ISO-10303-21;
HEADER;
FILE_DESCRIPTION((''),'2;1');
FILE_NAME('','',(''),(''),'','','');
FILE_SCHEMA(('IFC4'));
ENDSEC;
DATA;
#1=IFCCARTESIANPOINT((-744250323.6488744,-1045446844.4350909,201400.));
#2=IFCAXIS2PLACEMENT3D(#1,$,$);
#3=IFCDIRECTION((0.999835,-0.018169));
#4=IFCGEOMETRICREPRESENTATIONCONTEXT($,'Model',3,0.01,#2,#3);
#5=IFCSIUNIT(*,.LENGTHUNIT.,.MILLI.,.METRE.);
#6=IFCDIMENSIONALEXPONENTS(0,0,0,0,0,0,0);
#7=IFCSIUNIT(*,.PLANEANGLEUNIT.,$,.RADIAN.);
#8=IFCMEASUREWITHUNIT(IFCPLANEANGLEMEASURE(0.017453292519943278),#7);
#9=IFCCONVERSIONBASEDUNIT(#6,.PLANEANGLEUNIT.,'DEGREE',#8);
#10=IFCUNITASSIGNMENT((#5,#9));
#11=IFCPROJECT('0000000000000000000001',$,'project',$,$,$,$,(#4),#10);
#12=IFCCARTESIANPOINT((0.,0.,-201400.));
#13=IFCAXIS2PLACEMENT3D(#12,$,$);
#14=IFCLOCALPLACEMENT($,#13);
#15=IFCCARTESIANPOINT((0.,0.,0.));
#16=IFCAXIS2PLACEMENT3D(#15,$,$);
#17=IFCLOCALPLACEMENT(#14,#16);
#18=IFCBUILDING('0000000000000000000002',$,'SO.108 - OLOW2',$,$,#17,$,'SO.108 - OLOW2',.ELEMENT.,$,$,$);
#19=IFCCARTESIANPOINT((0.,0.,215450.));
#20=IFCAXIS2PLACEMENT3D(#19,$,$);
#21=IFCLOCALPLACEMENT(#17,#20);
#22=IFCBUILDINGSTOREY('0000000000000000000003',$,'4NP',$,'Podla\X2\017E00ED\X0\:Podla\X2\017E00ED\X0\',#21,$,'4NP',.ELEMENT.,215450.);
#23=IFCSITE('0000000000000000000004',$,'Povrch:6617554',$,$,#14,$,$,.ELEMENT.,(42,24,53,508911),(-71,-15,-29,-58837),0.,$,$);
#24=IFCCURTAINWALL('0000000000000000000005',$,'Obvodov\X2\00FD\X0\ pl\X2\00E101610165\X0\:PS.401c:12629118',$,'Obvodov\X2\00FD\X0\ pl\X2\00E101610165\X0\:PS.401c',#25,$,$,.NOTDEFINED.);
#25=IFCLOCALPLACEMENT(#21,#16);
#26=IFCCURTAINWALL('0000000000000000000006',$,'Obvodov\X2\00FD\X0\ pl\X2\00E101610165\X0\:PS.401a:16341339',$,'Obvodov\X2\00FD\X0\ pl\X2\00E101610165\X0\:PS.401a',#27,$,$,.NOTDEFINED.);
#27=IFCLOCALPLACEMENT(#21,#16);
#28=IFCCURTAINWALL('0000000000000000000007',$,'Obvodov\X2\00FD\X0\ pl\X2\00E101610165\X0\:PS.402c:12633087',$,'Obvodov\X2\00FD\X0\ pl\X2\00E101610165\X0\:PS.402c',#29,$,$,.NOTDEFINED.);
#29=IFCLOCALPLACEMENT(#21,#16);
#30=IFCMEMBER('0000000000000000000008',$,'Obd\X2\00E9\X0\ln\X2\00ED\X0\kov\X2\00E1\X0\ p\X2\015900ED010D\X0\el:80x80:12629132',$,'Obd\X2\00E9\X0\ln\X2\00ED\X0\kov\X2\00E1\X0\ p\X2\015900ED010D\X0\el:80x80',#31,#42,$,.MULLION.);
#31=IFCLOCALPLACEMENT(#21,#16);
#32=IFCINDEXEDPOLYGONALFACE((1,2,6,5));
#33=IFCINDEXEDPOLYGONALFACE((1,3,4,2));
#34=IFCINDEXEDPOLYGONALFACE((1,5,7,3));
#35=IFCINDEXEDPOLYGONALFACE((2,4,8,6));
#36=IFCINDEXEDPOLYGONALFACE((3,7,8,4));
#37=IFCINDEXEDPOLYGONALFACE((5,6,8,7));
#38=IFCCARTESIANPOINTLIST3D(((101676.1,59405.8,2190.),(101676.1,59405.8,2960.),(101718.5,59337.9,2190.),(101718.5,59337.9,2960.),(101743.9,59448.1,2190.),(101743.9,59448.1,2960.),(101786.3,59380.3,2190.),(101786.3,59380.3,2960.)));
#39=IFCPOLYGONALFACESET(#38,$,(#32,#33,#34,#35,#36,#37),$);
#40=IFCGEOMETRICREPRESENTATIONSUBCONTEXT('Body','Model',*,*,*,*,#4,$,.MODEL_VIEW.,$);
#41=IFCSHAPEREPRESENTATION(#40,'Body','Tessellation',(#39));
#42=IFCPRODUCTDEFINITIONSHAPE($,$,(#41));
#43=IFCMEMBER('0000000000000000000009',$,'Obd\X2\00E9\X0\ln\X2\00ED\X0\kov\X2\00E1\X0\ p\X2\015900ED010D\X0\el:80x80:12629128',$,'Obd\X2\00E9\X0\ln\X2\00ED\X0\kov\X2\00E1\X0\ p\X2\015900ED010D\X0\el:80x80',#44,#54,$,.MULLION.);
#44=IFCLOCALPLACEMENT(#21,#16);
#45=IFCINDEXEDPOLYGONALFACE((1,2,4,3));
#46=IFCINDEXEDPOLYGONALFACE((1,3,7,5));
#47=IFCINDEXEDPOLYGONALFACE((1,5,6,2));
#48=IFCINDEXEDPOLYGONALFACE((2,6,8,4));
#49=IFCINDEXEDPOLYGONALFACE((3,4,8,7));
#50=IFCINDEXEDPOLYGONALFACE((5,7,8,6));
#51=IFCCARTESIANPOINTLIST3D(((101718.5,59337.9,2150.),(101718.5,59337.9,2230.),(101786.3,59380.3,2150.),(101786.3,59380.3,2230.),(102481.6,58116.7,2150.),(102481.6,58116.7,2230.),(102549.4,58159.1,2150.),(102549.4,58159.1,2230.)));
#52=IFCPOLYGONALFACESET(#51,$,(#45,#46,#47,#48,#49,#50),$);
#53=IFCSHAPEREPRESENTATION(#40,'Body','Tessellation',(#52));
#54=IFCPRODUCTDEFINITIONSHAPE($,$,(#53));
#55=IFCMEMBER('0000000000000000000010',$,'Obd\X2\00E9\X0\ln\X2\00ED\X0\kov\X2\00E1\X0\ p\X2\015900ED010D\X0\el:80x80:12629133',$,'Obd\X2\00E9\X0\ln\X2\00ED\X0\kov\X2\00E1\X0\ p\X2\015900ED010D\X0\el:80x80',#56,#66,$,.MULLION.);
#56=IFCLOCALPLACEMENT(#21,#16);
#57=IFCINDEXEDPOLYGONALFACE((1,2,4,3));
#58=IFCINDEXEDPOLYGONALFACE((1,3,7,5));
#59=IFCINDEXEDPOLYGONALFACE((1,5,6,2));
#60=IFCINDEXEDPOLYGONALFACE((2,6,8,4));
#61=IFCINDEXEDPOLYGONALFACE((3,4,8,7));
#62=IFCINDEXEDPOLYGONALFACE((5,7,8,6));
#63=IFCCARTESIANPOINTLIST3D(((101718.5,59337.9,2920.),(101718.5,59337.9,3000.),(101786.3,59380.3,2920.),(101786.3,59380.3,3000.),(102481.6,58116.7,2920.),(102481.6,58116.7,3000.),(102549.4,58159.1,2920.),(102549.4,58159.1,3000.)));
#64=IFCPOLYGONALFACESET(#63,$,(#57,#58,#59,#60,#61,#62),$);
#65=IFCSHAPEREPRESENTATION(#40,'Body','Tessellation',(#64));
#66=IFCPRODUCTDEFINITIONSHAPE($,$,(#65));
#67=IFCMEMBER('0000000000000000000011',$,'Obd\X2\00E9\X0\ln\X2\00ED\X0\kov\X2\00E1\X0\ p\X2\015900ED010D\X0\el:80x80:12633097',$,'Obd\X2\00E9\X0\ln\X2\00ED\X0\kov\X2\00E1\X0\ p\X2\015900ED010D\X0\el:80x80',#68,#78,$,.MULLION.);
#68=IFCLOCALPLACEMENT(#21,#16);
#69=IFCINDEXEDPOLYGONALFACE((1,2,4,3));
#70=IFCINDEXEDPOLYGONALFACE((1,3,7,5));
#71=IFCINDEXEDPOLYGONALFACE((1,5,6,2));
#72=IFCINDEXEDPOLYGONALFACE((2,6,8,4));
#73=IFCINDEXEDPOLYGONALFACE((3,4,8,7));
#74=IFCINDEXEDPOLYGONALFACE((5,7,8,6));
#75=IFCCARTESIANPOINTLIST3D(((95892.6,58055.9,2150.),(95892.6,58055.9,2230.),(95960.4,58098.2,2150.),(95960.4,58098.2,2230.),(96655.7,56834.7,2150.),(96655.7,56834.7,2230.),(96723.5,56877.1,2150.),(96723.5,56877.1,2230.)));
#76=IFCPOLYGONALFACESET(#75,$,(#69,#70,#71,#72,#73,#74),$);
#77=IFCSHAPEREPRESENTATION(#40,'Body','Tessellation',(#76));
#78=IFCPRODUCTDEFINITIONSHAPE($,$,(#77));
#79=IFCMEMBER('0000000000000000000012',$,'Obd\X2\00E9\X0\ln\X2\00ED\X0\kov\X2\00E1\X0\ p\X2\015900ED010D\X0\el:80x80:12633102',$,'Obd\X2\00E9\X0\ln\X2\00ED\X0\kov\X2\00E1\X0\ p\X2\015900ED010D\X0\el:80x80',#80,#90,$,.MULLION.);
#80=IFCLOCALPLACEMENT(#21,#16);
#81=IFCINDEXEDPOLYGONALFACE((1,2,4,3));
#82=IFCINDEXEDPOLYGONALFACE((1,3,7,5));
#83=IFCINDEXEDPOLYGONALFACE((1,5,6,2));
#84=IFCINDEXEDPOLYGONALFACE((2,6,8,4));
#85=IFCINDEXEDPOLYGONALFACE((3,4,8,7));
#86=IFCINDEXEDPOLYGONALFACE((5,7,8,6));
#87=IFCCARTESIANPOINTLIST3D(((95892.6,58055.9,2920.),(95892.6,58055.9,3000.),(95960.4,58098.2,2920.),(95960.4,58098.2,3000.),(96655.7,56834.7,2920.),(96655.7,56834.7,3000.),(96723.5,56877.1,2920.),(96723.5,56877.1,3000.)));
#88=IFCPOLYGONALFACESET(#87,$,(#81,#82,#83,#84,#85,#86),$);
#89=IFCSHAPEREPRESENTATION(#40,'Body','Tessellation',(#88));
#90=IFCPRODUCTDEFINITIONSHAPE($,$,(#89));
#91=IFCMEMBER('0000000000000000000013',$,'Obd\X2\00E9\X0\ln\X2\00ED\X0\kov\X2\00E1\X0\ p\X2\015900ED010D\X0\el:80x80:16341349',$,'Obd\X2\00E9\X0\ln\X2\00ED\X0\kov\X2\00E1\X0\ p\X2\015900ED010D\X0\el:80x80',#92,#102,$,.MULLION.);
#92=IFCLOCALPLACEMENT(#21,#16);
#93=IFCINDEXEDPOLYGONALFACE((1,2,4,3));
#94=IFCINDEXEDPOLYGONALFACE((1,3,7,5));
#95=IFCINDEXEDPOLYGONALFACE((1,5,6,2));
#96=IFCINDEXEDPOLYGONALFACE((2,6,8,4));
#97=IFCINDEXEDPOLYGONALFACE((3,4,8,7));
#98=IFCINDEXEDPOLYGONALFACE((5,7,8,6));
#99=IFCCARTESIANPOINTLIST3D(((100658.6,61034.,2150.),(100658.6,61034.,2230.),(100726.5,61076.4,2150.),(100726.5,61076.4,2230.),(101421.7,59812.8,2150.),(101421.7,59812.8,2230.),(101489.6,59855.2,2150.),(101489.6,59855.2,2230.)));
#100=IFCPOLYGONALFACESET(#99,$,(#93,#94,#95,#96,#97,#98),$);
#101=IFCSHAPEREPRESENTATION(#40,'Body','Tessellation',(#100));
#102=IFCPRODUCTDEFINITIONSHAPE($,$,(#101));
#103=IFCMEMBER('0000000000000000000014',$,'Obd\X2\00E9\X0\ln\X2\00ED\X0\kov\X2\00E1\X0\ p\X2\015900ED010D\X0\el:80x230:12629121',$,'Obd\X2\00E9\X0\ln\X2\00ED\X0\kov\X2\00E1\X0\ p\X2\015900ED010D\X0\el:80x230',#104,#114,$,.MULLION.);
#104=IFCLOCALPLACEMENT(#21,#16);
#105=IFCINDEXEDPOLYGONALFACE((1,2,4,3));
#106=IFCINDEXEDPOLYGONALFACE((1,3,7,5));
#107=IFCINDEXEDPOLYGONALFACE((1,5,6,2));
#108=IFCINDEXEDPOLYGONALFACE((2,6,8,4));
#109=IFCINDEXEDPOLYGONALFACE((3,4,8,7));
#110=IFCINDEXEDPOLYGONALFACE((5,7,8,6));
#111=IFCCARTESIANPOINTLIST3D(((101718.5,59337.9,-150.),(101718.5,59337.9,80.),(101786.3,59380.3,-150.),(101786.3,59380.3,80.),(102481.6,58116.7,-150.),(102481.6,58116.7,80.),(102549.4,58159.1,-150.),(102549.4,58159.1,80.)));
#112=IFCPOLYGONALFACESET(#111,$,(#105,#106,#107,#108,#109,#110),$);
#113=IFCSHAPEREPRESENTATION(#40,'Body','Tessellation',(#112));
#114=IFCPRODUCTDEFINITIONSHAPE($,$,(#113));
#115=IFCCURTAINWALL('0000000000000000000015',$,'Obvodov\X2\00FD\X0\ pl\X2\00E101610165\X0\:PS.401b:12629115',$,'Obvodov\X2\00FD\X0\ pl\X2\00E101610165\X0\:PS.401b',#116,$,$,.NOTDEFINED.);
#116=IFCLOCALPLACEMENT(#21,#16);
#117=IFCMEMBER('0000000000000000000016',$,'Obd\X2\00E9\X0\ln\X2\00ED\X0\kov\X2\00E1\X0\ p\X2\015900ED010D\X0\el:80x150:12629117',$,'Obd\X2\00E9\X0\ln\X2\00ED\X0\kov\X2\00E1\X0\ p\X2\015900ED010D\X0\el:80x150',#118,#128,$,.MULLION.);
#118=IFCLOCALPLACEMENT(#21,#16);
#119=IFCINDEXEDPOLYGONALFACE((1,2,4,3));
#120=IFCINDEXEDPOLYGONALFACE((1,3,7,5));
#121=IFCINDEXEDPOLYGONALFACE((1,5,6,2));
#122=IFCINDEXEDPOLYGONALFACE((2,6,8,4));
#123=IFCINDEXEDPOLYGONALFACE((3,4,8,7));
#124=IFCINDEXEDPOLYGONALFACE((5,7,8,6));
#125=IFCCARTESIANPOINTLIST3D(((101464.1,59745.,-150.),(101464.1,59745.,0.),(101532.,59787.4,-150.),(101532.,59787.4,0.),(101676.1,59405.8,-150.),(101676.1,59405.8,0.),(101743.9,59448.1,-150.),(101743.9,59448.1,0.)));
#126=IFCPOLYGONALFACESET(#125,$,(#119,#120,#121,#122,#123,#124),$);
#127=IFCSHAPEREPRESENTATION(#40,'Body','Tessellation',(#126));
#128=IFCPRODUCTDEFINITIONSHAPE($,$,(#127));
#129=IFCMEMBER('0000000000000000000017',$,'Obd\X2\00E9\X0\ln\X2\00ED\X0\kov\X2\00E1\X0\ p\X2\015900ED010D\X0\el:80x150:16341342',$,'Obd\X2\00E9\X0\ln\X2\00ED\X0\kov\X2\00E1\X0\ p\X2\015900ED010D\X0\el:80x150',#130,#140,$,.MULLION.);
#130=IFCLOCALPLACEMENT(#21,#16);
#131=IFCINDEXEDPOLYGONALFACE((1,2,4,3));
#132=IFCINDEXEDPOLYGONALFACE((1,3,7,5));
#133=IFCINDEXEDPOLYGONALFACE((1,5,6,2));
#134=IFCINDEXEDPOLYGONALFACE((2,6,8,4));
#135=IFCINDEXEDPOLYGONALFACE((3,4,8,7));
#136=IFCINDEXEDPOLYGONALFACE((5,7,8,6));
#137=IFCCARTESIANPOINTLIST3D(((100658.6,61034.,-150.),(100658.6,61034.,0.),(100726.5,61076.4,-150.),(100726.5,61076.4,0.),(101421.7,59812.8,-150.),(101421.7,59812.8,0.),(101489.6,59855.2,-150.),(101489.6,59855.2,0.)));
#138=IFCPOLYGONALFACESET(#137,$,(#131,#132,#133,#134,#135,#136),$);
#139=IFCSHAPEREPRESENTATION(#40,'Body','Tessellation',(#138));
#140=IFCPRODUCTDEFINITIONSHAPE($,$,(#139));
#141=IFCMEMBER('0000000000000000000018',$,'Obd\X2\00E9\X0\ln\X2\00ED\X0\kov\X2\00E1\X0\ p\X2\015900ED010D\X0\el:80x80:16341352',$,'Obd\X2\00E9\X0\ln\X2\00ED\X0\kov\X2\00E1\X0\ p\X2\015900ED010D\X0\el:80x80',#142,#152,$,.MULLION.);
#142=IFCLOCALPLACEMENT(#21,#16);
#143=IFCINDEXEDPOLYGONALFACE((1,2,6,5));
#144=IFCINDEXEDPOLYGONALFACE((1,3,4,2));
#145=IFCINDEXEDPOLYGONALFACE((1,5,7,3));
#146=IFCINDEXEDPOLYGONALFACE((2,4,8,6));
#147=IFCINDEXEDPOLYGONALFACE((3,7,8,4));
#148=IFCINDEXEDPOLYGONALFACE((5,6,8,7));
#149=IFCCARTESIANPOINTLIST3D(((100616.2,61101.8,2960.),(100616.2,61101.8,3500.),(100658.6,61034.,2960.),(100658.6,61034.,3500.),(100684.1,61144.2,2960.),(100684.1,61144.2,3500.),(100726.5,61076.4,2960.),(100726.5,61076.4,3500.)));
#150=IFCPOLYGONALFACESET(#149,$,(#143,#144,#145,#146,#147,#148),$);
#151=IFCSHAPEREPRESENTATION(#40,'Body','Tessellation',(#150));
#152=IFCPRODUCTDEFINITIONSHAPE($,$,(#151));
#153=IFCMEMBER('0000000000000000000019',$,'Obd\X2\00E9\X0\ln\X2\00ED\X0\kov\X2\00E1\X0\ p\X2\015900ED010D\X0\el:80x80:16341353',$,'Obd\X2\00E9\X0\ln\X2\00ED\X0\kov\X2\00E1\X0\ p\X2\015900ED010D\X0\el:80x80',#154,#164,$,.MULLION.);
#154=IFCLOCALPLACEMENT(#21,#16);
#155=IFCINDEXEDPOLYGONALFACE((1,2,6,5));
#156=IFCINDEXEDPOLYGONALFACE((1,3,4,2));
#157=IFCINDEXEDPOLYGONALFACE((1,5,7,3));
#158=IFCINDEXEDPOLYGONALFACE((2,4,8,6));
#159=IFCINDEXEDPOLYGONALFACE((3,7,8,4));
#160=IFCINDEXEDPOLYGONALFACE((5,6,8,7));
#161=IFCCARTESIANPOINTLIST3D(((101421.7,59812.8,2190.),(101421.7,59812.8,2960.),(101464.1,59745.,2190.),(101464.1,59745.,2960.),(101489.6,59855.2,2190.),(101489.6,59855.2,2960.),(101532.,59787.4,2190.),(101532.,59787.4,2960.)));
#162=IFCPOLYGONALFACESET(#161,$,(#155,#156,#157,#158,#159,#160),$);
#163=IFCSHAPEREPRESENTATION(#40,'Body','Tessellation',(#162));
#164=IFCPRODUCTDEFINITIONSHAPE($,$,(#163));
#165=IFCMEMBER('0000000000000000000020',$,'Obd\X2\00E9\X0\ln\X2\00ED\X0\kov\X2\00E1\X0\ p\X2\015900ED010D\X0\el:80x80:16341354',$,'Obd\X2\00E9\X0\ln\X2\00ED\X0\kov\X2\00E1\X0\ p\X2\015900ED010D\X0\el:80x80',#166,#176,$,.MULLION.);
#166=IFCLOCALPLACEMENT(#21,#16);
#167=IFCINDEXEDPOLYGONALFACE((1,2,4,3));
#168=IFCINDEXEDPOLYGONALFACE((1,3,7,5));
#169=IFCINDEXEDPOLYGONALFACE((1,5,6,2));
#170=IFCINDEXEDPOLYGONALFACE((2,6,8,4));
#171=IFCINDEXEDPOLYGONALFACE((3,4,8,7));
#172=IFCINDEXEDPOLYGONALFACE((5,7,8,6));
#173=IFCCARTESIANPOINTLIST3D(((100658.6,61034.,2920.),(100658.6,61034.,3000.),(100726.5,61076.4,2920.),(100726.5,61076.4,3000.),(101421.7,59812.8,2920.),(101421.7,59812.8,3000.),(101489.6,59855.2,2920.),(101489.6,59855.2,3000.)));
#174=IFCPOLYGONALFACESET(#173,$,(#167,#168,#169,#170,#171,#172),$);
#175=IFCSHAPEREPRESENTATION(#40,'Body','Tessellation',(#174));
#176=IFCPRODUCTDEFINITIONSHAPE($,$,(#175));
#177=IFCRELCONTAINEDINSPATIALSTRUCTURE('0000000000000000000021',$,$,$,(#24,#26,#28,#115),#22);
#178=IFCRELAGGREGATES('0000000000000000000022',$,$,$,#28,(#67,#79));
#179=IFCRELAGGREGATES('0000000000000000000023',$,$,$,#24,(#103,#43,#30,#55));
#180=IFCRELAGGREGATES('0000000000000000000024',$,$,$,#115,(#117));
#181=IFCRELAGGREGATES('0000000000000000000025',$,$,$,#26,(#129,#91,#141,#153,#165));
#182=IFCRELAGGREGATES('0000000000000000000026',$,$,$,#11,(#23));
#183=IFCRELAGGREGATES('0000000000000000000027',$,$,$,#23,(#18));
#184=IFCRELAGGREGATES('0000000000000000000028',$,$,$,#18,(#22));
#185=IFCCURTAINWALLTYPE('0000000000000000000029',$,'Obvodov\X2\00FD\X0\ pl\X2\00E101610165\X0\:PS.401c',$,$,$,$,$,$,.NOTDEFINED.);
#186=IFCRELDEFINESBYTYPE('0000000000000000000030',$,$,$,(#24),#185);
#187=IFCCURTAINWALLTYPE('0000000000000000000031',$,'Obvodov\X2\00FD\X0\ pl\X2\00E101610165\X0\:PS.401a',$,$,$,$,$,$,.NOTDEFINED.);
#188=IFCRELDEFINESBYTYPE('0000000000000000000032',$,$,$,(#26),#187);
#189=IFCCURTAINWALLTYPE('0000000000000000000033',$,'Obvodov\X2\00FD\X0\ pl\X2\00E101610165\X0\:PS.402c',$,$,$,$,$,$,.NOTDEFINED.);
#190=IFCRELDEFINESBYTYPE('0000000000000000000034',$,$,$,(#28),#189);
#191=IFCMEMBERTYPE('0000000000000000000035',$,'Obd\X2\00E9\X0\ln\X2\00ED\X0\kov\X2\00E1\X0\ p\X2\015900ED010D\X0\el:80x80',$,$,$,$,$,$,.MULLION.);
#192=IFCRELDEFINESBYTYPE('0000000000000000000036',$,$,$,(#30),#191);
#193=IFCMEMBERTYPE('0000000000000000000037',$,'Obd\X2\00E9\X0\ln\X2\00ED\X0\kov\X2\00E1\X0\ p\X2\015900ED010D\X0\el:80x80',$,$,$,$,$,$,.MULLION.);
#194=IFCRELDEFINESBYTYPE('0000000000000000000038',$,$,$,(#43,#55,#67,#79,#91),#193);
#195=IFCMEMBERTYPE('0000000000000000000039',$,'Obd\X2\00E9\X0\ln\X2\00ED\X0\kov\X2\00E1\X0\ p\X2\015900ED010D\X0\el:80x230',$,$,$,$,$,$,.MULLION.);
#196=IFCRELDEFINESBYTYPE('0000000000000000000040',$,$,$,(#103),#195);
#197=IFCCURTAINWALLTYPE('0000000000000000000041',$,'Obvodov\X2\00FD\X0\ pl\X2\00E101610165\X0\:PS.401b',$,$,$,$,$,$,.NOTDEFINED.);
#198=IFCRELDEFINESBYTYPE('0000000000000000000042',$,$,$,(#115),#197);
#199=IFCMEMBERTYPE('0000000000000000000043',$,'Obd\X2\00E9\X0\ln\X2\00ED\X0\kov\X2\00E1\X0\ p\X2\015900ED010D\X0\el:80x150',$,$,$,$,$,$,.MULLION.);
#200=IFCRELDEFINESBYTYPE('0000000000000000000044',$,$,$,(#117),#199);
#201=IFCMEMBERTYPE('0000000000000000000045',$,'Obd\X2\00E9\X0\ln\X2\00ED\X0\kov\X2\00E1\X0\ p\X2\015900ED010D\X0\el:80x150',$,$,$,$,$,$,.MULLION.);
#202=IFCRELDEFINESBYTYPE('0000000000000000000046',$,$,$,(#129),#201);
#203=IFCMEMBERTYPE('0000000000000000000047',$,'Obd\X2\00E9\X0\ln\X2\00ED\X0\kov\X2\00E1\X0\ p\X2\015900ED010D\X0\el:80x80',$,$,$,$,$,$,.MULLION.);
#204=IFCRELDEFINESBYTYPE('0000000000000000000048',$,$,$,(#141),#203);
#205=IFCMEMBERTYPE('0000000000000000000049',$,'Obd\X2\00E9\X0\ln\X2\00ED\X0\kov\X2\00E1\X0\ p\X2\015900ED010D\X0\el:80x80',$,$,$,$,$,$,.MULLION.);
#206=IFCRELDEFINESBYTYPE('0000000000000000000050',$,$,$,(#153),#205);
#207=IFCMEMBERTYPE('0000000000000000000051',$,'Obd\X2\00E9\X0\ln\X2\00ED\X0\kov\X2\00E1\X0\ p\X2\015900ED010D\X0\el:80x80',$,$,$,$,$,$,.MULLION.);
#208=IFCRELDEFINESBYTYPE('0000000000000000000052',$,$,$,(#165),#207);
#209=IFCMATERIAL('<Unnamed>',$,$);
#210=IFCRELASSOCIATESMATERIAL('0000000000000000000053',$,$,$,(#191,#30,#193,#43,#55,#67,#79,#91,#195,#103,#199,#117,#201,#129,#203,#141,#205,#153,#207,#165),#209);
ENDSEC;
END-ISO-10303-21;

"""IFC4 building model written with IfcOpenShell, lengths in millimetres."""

from ifc_helpers import new_model, entity, si_unit, converted_unit, direction, frame, origin, place, context, subcontext, project, spatial, indexed_curve, outline, extrude, source, transform, mapped, material, type_object, type_shapes, element, aggregate, save


model = new_model("IFC4")

# Units and contexts
model_context = context("Model", 3, precision=0.01, world=frame((-744250323.6488744, -1045446844.4350909, 201400.0)), true_north=direction((0.999835, -0.018169)))
body_context = subcontext(model_context, "Body", "Model", "MODEL_VIEW")
ifc_project = project(units=[si_unit("LENGTHUNIT", "METRE", prefix="MILLI"), converted_unit("PLANEANGLEUNIT", "DEGREE", entity("IfcPlaneAngleMeasure", 0.017453292519943278), si_unit("PLANEANGLEUNIT", "RADIAN"), dimensions=[0, 0, 0, 0, 0, 0, 0])], contexts=[model_context])

# Site, building, storey
site_placement = place(None, frame((0.0, 0.0, -201400.0)))
site = spatial("IfcSite", under=ifc_project, at=site_placement, Name="Povrch:6617554", CompositionType="ELEMENT", RefLatitude=(42, 24, 53, 508911), RefLongitude=(-71, -15, -29, -58837), RefElevation=0.0)
building_placement = place(site_placement, origin())
building = spatial("IfcBuilding", under=site, at=building_placement, Name="SO.108 - OLOW2", LongName="SO.108 - OLOW2", CompositionType="ELEMENT")
storey_placement = place(building_placement, frame((0.0, 0.0, 215450.0)))
storey = spatial("IfcBuildingStorey", under=building, at=storey_placement, Name="4NP", ObjectType="Podlaží:Podlaží", LongName="4NP", CompositionType="ELEMENT", Elevation=215450.0)

# Curtain walls
curtain_wall_type_1 = type_object("IfcCurtainWallType", Name="Obvodový plášť:PS.401c", PredefinedType="NOTDEFINED")
curtain_wall_1_placement = place(storey_placement, frame((0.0, 0.0, -215450.0)))
curtain_wall_1 = element("IfcCurtainWall", 1, at=curtain_wall_1_placement, inside=storey, type_object=curtain_wall_type_1, Name="Obvodový plášť:PS.401c:12629118", ObjectType="Obvodový plášť:PS.401c", PredefinedType="NOTDEFINED")
ifc_material_1 = material(Name="<Unnamed>")
curtain_wall_type_2 = type_object("IfcCurtainWallType", Name="Obvodový plášť:PS.401a", PredefinedType="NOTDEFINED")
curtain_wall_2_placement = place(storey_placement, frame((0.0, 0.0, -215450.0)))
curtain_wall_2 = element("IfcCurtainWall", 2, at=curtain_wall_2_placement, inside=storey, type_object=curtain_wall_type_2, Name="Obvodový plášť:PS.401a:16341339", ObjectType="Obvodový plášť:PS.401a", PredefinedType="NOTDEFINED")

# Curtain wall
curtain_wall_type_3 = type_object("IfcCurtainWallType", Name="Obvodový plášť:PS.402c", PredefinedType="NOTDEFINED")
curtain_wall_3_placement = place(storey_placement, frame((0.0, 0.0, -215450.0)))
curtain_wall_3 = element("IfcCurtainWall", 3, at=curtain_wall_3_placement, inside=storey, type_object=curtain_wall_type_3, Name="Obvodový plášť:PS.402c:12633087", ObjectType="Obvodový plášť:PS.402c", PredefinedType="NOTDEFINED")

# Members
member_type_1 = type_object("IfcMemberType", Name="Obdélníková příčel:80x80", PredefinedType="MULLION", material=ifc_material_1)
shared_shape_1 = source(origin(), body_context, "Body", "SweptSolid", [
    extrude(outline(indexed_curve([(-40.0, -40.0), (40.0, -40.0), (40.0, 40.0), (-40.0, 40.0), (-40.0, -40.0)], self_intersect=False)), frame((-40.0, 0.0, -770.0), z_axis=(0.0, 0.0, 1.0), x_axis=(-1.0, 0.0, 0.0)), (0.0, 0.0, 1.0), 770.0),
])
type_shapes(member_type_1, [shared_shape_1])
member_1_placement = place(curtain_wall_1_placement, frame((101710.0, 59426.9, 218410.0), z_axis=(0.0, 0.0, 1.0), x_axis=(-0.529919, 0.848048, 0.0)))
member_1 = element("IfcMember", 4, at=member_1_placement, type_object=member_type_1, material=ifc_material_1, Name="Obdélníková příčel:80x80:12629132", ObjectType="Obdélníková příčel:80x80", PredefinedType="MULLION", context=body_context, shape_type="MappedRepresentation", body=[
    mapped(shared_shape_1, transform((0.0, 0.0, 0.0), scale=1.0)),
])
member_type_2 = type_object("IfcMemberType", Name="Obdélníková příčel:80x80", PredefinedType="MULLION", material=ifc_material_1)
shared_shape_2 = source(origin(), body_context, "Body", "SweptSolid", [
    extrude(outline(indexed_curve([(-40.0, -40.0), (40.0, -40.0), (40.0, 40.0), (-40.0, 40.0), (-40.0, -40.0)], self_intersect=False)), frame((0.0, 0.0, -1440.0), z_axis=(0.0, 0.0, 1.0), x_axis=(-1.0, 0.0, 0.0)), (0.0, 0.0, 1.0), 1440.0),
])
type_shapes(member_type_2, [shared_shape_2])
member_2_placement = place(curtain_wall_1_placement, frame((102515.5, 58137.9, 217640.0), z_axis=(0.529919, -0.848048, 0.0), x_axis=(0.0, 0.0, 1.0)))
member_2 = element("IfcMember", 5, at=member_2_placement, type_object=member_type_2, material=ifc_material_1, Name="Obdélníková příčel:80x80:12629128", ObjectType="Obdélníková příčel:80x80", PredefinedType="MULLION", context=body_context, shape_type="MappedRepresentation", body=[
    mapped(shared_shape_2, transform((0.0, 0.0, 0.0), scale=1.0)),
])
member_3_placement = place(curtain_wall_1_placement, frame((102515.5, 58137.9, 218410.0), z_axis=(0.529919, -0.848048, 0.0), x_axis=(0.0, 0.0, 1.0)))
member_3 = element("IfcMember", 6, at=member_3_placement, type_object=member_type_2, material=ifc_material_1, Name="Obdélníková příčel:80x80:12629133", ObjectType="Obdélníková příčel:80x80", PredefinedType="MULLION", context=body_context, shape_type="MappedRepresentation", body=[
    mapped(shared_shape_2, transform((0.0, 0.0, 0.0), scale=1.0)),
])
member_4_placement = place(curtain_wall_3_placement, frame((95926.5, 58077.0, 217640.0), z_axis=(-0.529919, 0.848048, 0.0), x_axis=(0.0, 0.0, 1.0)))
member_4 = element("IfcMember", 7, at=member_4_placement, type_object=member_type_2, material=ifc_material_1, Name="Obdélníková příčel:80x80:12633097", ObjectType="Obdélníková příčel:80x80", PredefinedType="MULLION", context=body_context, shape_type="MappedRepresentation", body=[
    mapped(shared_shape_2, transform((0.0, 0.0, 0.0), scale=1.0)),
])
member_5_placement = place(curtain_wall_3_placement, frame((95926.5, 58077.0, 218410.0), z_axis=(-0.529919, 0.848048, 0.0), x_axis=(0.0, 0.0, 1.0)))
member_5 = element("IfcMember", 8, at=member_5_placement, type_object=member_type_2, material=ifc_material_1, Name="Obdélníková příčel:80x80:12633102", ObjectType="Obdélníková příčel:80x80", PredefinedType="MULLION", context=body_context, shape_type="MappedRepresentation", body=[
    mapped(shared_shape_2, transform((0.0, 0.0, 0.0), scale=1.0)),
])
aggregate(curtain_wall_3, [member_4, member_5])
member_6_placement = place(curtain_wall_2_placement, frame((100692.6, 61055.2, 217640.0), z_axis=(-0.529919, 0.848048, 0.0), x_axis=(0.0, 0.0, 1.0)))
member_6 = element("IfcMember", 9, at=member_6_placement, type_object=member_type_2, material=ifc_material_1, Name="Obdélníková příčel:80x80:16341349", ObjectType="Obdélníková příčel:80x80", PredefinedType="MULLION", context=body_context, shape_type="MappedRepresentation", body=[
    mapped(shared_shape_2, transform((0.0, 0.0, 0.0), scale=1.0)),
])
member_type_3 = type_object("IfcMemberType", Name="Obdélníková příčel:80x230", PredefinedType="MULLION", material=ifc_material_1)
shared_shape_3 = source(origin(), body_context, "Body", "SweptSolid", [
    extrude(outline(indexed_curve([(-115.0, -40.0), (115.0, -40.0), (115.0, 40.0), (-115.0, 40.0), (-115.0, -40.0)], self_intersect=False)), frame((-115.0, 0.0, -1440.0), z_axis=(0.0, 0.0, 1.0), x_axis=(-1.0, 0.0, 0.0)), (0.0, 0.0, 1.0), 1440.0),
])
type_shapes(member_type_3, [shared_shape_3])
member_7_placement = place(curtain_wall_1_placement, frame((101752.4, 59359.1, 215300.0), z_axis=(-0.529919, 0.848048, 0.0), x_axis=(0.0, 0.0, -1.0)))
member_7 = element("IfcMember", 10, at=member_7_placement, type_object=member_type_3, material=ifc_material_1, Name="Obdélníková příčel:80x230:12629121", ObjectType="Obdélníková příčel:80x230", PredefinedType="MULLION", context=body_context, shape_type="MappedRepresentation", body=[
    mapped(shared_shape_3, transform((0.0, 0.0, 0.0), scale=1.0)),
])

# Curtain wall, member
curtain_wall_type_4 = type_object("IfcCurtainWallType", Name="Obvodový plášť:PS.401b", PredefinedType="NOTDEFINED")
curtain_wall_4_placement = place(storey_placement, frame((0.0, 0.0, -215450.0)))
curtain_wall_4 = element("IfcCurtainWall", 11, at=curtain_wall_4_placement, inside=storey, type_object=curtain_wall_type_4, Name="Obvodový plášť:PS.401b:12629115", ObjectType="Obvodový plášť:PS.401b", PredefinedType="NOTDEFINED")
member_type_4 = type_object("IfcMemberType", Name="Obdélníková příčel:80x150", PredefinedType="MULLION", material=ifc_material_1)
shared_shape_4 = source(origin(), body_context, "Body", "SweptSolid", [
    extrude(outline(indexed_curve([(-75.0, -40.0), (75.0, -40.0), (75.0, 40.0), (-75.0, 40.0), (-75.0, -40.0)], self_intersect=False)), frame((-75.0, 0.0, -400.0), z_axis=(0.0, 0.0, 1.0), x_axis=(-1.0, 0.0, 0.0)), (0.0, 0.0, 1.0), 400.0),
])
type_shapes(member_type_4, [shared_shape_4])
member_8_placement = place(curtain_wall_4_placement, frame((101710.0, 59426.9, 215300.0), z_axis=(0.529919, -0.848048, 0.0), x_axis=(0.0, 0.0, -1.0)))
member_8 = element("IfcMember", 12, at=member_8_placement, type_object=member_type_4, material=ifc_material_1, Name="Obdélníková příčel:80x150:12629117", ObjectType="Obdélníková příčel:80x150", PredefinedType="MULLION", context=body_context, shape_type="MappedRepresentation", body=[
    mapped(shared_shape_4, transform((0.0, 0.0, 0.0), scale=1.0)),
])

# Members
member_type_5 = type_object("IfcMemberType", Name="Obdélníková příčel:80x150", PredefinedType="MULLION", material=ifc_material_1)
shared_shape_5 = source(origin(), body_context, "Body", "SweptSolid", [
    extrude(outline(indexed_curve([(-75.0, -40.0), (75.0, -40.0), (75.0, 40.0), (-75.0, 40.0), (-75.0, -40.0)], self_intersect=False)), frame((-75.0, 0.0, -1440.0), z_axis=(0.0, 0.0, 1.0), x_axis=(-1.0, 0.0, 0.0)), (0.0, 0.0, 1.0), 1440.0),
])
type_shapes(member_type_5, [shared_shape_5])
member_9_placement = place(curtain_wall_2_placement, frame((101455.6, 59834.0, 215300.0), z_axis=(0.529919, -0.848048, 0.0), x_axis=(0.0, 0.0, -1.0)))
member_9 = element("IfcMember", 13, at=member_9_placement, type_object=member_type_5, material=ifc_material_1, Name="Obdélníková příčel:80x150:16341342", ObjectType="Obdélníková příčel:80x150", PredefinedType="MULLION", context=body_context, shape_type="MappedRepresentation", body=[
    mapped(shared_shape_5, transform((0.0, 0.0, 0.0), scale=1.0)),
])
member_type_6 = type_object("IfcMemberType", Name="Obdélníková příčel:80x80", PredefinedType="MULLION", material=ifc_material_1)
shared_shape_6 = source(origin(), body_context, "Body", "SweptSolid", [
    extrude(outline(indexed_curve([(-40.0, -40.0), (40.0, -40.0), (40.0, 40.0), (-40.0, 40.0), (-40.0, -40.0)], self_intersect=False)), frame((-40.0, 0.0, -540.0), z_axis=(0.0, 0.0, 1.0), x_axis=(-1.0, 0.0, 0.0)), (0.0, 0.0, 1.0), 540.0),
])
type_shapes(member_type_6, [shared_shape_6])
member_10_placement = place(curtain_wall_2_placement, frame((100650.2, 61123.0, 218410.0), z_axis=(0.0, 0.0, -1.0), x_axis=(-0.529919, 0.848048, 0.0)))
member_10 = element("IfcMember", 14, at=member_10_placement, type_object=member_type_6, material=ifc_material_1, Name="Obdélníková příčel:80x80:16341352", ObjectType="Obdélníková příčel:80x80", PredefinedType="MULLION", context=body_context, shape_type="MappedRepresentation", body=[
    mapped(shared_shape_6, transform((0.0, 0.0, 0.0), scale=1.0)),
])
member_type_7 = type_object("IfcMemberType", Name="Obdélníková příčel:80x80", PredefinedType="MULLION", material=ifc_material_1)
shared_shape_7 = source(origin(), body_context, "Body", "SweptSolid", [
    extrude(outline(indexed_curve([(-40.0, -40.0), (40.0, -40.0), (40.0, 40.0), (-40.0, 40.0), (-40.0, -40.0)], self_intersect=False)), frame((-40.0, 0.0, -770.0), z_axis=(0.0, 0.0, 1.0), x_axis=(-1.0, 0.0, 0.0)), (0.0, 0.0, 1.0), 770.0),
])
type_shapes(member_type_7, [shared_shape_7])
member_11_placement = place(curtain_wall_2_placement, frame((101498.0, 59766.2, 218410.0), z_axis=(0.0, 0.0, 1.0), x_axis=(0.529919, -0.848048, 0.0)))
member_11 = element("IfcMember", 15, at=member_11_placement, type_object=member_type_7, material=ifc_material_1, Name="Obdélníková příčel:80x80:16341353", ObjectType="Obdélníková příčel:80x80", PredefinedType="MULLION", context=body_context, shape_type="MappedRepresentation", body=[
    mapped(shared_shape_7, transform((0.0, 0.0, 0.0), scale=1.0)),
])
member_type_8 = type_object("IfcMemberType", Name="Obdélníková příčel:80x80", PredefinedType="MULLION", material=ifc_material_1)
shared_shape_8 = source(origin(), body_context, "Body", "SweptSolid", [
    extrude(outline(indexed_curve([(-40.0, -40.0), (40.0, -40.0), (40.0, 40.0), (-40.0, 40.0), (-40.0, -40.0)], self_intersect=False)), frame((0.0, 0.0, -1440.0), z_axis=(0.0, 0.0, 1.0), x_axis=(-1.0, 0.0, 0.0)), (0.0, 0.0, 1.0), 1440.0),
])
type_shapes(member_type_8, [shared_shape_8])
member_12_placement = place(curtain_wall_2_placement, frame((100692.6, 61055.2, 218410.0), z_axis=(-0.529919, 0.848048, 0.0), x_axis=(0.0, 0.0, 1.0)))
member_12 = element("IfcMember", 16, at=member_12_placement, type_object=member_type_8, material=ifc_material_1, Name="Obdélníková příčel:80x80:16341354", ObjectType="Obdélníková příčel:80x80", PredefinedType="MULLION", context=body_context, shape_type="MappedRepresentation", body=[
    mapped(shared_shape_8, transform((0.0, 0.0, 0.0), scale=1.0)),
])

aggregate(curtain_wall_1, [member_7, member_2, member_1, member_3])
aggregate(curtain_wall_4, [member_8])

aggregate(curtain_wall_2, [member_9, member_6, member_10, member_11, member_12])

save(model, "model.ifc")
